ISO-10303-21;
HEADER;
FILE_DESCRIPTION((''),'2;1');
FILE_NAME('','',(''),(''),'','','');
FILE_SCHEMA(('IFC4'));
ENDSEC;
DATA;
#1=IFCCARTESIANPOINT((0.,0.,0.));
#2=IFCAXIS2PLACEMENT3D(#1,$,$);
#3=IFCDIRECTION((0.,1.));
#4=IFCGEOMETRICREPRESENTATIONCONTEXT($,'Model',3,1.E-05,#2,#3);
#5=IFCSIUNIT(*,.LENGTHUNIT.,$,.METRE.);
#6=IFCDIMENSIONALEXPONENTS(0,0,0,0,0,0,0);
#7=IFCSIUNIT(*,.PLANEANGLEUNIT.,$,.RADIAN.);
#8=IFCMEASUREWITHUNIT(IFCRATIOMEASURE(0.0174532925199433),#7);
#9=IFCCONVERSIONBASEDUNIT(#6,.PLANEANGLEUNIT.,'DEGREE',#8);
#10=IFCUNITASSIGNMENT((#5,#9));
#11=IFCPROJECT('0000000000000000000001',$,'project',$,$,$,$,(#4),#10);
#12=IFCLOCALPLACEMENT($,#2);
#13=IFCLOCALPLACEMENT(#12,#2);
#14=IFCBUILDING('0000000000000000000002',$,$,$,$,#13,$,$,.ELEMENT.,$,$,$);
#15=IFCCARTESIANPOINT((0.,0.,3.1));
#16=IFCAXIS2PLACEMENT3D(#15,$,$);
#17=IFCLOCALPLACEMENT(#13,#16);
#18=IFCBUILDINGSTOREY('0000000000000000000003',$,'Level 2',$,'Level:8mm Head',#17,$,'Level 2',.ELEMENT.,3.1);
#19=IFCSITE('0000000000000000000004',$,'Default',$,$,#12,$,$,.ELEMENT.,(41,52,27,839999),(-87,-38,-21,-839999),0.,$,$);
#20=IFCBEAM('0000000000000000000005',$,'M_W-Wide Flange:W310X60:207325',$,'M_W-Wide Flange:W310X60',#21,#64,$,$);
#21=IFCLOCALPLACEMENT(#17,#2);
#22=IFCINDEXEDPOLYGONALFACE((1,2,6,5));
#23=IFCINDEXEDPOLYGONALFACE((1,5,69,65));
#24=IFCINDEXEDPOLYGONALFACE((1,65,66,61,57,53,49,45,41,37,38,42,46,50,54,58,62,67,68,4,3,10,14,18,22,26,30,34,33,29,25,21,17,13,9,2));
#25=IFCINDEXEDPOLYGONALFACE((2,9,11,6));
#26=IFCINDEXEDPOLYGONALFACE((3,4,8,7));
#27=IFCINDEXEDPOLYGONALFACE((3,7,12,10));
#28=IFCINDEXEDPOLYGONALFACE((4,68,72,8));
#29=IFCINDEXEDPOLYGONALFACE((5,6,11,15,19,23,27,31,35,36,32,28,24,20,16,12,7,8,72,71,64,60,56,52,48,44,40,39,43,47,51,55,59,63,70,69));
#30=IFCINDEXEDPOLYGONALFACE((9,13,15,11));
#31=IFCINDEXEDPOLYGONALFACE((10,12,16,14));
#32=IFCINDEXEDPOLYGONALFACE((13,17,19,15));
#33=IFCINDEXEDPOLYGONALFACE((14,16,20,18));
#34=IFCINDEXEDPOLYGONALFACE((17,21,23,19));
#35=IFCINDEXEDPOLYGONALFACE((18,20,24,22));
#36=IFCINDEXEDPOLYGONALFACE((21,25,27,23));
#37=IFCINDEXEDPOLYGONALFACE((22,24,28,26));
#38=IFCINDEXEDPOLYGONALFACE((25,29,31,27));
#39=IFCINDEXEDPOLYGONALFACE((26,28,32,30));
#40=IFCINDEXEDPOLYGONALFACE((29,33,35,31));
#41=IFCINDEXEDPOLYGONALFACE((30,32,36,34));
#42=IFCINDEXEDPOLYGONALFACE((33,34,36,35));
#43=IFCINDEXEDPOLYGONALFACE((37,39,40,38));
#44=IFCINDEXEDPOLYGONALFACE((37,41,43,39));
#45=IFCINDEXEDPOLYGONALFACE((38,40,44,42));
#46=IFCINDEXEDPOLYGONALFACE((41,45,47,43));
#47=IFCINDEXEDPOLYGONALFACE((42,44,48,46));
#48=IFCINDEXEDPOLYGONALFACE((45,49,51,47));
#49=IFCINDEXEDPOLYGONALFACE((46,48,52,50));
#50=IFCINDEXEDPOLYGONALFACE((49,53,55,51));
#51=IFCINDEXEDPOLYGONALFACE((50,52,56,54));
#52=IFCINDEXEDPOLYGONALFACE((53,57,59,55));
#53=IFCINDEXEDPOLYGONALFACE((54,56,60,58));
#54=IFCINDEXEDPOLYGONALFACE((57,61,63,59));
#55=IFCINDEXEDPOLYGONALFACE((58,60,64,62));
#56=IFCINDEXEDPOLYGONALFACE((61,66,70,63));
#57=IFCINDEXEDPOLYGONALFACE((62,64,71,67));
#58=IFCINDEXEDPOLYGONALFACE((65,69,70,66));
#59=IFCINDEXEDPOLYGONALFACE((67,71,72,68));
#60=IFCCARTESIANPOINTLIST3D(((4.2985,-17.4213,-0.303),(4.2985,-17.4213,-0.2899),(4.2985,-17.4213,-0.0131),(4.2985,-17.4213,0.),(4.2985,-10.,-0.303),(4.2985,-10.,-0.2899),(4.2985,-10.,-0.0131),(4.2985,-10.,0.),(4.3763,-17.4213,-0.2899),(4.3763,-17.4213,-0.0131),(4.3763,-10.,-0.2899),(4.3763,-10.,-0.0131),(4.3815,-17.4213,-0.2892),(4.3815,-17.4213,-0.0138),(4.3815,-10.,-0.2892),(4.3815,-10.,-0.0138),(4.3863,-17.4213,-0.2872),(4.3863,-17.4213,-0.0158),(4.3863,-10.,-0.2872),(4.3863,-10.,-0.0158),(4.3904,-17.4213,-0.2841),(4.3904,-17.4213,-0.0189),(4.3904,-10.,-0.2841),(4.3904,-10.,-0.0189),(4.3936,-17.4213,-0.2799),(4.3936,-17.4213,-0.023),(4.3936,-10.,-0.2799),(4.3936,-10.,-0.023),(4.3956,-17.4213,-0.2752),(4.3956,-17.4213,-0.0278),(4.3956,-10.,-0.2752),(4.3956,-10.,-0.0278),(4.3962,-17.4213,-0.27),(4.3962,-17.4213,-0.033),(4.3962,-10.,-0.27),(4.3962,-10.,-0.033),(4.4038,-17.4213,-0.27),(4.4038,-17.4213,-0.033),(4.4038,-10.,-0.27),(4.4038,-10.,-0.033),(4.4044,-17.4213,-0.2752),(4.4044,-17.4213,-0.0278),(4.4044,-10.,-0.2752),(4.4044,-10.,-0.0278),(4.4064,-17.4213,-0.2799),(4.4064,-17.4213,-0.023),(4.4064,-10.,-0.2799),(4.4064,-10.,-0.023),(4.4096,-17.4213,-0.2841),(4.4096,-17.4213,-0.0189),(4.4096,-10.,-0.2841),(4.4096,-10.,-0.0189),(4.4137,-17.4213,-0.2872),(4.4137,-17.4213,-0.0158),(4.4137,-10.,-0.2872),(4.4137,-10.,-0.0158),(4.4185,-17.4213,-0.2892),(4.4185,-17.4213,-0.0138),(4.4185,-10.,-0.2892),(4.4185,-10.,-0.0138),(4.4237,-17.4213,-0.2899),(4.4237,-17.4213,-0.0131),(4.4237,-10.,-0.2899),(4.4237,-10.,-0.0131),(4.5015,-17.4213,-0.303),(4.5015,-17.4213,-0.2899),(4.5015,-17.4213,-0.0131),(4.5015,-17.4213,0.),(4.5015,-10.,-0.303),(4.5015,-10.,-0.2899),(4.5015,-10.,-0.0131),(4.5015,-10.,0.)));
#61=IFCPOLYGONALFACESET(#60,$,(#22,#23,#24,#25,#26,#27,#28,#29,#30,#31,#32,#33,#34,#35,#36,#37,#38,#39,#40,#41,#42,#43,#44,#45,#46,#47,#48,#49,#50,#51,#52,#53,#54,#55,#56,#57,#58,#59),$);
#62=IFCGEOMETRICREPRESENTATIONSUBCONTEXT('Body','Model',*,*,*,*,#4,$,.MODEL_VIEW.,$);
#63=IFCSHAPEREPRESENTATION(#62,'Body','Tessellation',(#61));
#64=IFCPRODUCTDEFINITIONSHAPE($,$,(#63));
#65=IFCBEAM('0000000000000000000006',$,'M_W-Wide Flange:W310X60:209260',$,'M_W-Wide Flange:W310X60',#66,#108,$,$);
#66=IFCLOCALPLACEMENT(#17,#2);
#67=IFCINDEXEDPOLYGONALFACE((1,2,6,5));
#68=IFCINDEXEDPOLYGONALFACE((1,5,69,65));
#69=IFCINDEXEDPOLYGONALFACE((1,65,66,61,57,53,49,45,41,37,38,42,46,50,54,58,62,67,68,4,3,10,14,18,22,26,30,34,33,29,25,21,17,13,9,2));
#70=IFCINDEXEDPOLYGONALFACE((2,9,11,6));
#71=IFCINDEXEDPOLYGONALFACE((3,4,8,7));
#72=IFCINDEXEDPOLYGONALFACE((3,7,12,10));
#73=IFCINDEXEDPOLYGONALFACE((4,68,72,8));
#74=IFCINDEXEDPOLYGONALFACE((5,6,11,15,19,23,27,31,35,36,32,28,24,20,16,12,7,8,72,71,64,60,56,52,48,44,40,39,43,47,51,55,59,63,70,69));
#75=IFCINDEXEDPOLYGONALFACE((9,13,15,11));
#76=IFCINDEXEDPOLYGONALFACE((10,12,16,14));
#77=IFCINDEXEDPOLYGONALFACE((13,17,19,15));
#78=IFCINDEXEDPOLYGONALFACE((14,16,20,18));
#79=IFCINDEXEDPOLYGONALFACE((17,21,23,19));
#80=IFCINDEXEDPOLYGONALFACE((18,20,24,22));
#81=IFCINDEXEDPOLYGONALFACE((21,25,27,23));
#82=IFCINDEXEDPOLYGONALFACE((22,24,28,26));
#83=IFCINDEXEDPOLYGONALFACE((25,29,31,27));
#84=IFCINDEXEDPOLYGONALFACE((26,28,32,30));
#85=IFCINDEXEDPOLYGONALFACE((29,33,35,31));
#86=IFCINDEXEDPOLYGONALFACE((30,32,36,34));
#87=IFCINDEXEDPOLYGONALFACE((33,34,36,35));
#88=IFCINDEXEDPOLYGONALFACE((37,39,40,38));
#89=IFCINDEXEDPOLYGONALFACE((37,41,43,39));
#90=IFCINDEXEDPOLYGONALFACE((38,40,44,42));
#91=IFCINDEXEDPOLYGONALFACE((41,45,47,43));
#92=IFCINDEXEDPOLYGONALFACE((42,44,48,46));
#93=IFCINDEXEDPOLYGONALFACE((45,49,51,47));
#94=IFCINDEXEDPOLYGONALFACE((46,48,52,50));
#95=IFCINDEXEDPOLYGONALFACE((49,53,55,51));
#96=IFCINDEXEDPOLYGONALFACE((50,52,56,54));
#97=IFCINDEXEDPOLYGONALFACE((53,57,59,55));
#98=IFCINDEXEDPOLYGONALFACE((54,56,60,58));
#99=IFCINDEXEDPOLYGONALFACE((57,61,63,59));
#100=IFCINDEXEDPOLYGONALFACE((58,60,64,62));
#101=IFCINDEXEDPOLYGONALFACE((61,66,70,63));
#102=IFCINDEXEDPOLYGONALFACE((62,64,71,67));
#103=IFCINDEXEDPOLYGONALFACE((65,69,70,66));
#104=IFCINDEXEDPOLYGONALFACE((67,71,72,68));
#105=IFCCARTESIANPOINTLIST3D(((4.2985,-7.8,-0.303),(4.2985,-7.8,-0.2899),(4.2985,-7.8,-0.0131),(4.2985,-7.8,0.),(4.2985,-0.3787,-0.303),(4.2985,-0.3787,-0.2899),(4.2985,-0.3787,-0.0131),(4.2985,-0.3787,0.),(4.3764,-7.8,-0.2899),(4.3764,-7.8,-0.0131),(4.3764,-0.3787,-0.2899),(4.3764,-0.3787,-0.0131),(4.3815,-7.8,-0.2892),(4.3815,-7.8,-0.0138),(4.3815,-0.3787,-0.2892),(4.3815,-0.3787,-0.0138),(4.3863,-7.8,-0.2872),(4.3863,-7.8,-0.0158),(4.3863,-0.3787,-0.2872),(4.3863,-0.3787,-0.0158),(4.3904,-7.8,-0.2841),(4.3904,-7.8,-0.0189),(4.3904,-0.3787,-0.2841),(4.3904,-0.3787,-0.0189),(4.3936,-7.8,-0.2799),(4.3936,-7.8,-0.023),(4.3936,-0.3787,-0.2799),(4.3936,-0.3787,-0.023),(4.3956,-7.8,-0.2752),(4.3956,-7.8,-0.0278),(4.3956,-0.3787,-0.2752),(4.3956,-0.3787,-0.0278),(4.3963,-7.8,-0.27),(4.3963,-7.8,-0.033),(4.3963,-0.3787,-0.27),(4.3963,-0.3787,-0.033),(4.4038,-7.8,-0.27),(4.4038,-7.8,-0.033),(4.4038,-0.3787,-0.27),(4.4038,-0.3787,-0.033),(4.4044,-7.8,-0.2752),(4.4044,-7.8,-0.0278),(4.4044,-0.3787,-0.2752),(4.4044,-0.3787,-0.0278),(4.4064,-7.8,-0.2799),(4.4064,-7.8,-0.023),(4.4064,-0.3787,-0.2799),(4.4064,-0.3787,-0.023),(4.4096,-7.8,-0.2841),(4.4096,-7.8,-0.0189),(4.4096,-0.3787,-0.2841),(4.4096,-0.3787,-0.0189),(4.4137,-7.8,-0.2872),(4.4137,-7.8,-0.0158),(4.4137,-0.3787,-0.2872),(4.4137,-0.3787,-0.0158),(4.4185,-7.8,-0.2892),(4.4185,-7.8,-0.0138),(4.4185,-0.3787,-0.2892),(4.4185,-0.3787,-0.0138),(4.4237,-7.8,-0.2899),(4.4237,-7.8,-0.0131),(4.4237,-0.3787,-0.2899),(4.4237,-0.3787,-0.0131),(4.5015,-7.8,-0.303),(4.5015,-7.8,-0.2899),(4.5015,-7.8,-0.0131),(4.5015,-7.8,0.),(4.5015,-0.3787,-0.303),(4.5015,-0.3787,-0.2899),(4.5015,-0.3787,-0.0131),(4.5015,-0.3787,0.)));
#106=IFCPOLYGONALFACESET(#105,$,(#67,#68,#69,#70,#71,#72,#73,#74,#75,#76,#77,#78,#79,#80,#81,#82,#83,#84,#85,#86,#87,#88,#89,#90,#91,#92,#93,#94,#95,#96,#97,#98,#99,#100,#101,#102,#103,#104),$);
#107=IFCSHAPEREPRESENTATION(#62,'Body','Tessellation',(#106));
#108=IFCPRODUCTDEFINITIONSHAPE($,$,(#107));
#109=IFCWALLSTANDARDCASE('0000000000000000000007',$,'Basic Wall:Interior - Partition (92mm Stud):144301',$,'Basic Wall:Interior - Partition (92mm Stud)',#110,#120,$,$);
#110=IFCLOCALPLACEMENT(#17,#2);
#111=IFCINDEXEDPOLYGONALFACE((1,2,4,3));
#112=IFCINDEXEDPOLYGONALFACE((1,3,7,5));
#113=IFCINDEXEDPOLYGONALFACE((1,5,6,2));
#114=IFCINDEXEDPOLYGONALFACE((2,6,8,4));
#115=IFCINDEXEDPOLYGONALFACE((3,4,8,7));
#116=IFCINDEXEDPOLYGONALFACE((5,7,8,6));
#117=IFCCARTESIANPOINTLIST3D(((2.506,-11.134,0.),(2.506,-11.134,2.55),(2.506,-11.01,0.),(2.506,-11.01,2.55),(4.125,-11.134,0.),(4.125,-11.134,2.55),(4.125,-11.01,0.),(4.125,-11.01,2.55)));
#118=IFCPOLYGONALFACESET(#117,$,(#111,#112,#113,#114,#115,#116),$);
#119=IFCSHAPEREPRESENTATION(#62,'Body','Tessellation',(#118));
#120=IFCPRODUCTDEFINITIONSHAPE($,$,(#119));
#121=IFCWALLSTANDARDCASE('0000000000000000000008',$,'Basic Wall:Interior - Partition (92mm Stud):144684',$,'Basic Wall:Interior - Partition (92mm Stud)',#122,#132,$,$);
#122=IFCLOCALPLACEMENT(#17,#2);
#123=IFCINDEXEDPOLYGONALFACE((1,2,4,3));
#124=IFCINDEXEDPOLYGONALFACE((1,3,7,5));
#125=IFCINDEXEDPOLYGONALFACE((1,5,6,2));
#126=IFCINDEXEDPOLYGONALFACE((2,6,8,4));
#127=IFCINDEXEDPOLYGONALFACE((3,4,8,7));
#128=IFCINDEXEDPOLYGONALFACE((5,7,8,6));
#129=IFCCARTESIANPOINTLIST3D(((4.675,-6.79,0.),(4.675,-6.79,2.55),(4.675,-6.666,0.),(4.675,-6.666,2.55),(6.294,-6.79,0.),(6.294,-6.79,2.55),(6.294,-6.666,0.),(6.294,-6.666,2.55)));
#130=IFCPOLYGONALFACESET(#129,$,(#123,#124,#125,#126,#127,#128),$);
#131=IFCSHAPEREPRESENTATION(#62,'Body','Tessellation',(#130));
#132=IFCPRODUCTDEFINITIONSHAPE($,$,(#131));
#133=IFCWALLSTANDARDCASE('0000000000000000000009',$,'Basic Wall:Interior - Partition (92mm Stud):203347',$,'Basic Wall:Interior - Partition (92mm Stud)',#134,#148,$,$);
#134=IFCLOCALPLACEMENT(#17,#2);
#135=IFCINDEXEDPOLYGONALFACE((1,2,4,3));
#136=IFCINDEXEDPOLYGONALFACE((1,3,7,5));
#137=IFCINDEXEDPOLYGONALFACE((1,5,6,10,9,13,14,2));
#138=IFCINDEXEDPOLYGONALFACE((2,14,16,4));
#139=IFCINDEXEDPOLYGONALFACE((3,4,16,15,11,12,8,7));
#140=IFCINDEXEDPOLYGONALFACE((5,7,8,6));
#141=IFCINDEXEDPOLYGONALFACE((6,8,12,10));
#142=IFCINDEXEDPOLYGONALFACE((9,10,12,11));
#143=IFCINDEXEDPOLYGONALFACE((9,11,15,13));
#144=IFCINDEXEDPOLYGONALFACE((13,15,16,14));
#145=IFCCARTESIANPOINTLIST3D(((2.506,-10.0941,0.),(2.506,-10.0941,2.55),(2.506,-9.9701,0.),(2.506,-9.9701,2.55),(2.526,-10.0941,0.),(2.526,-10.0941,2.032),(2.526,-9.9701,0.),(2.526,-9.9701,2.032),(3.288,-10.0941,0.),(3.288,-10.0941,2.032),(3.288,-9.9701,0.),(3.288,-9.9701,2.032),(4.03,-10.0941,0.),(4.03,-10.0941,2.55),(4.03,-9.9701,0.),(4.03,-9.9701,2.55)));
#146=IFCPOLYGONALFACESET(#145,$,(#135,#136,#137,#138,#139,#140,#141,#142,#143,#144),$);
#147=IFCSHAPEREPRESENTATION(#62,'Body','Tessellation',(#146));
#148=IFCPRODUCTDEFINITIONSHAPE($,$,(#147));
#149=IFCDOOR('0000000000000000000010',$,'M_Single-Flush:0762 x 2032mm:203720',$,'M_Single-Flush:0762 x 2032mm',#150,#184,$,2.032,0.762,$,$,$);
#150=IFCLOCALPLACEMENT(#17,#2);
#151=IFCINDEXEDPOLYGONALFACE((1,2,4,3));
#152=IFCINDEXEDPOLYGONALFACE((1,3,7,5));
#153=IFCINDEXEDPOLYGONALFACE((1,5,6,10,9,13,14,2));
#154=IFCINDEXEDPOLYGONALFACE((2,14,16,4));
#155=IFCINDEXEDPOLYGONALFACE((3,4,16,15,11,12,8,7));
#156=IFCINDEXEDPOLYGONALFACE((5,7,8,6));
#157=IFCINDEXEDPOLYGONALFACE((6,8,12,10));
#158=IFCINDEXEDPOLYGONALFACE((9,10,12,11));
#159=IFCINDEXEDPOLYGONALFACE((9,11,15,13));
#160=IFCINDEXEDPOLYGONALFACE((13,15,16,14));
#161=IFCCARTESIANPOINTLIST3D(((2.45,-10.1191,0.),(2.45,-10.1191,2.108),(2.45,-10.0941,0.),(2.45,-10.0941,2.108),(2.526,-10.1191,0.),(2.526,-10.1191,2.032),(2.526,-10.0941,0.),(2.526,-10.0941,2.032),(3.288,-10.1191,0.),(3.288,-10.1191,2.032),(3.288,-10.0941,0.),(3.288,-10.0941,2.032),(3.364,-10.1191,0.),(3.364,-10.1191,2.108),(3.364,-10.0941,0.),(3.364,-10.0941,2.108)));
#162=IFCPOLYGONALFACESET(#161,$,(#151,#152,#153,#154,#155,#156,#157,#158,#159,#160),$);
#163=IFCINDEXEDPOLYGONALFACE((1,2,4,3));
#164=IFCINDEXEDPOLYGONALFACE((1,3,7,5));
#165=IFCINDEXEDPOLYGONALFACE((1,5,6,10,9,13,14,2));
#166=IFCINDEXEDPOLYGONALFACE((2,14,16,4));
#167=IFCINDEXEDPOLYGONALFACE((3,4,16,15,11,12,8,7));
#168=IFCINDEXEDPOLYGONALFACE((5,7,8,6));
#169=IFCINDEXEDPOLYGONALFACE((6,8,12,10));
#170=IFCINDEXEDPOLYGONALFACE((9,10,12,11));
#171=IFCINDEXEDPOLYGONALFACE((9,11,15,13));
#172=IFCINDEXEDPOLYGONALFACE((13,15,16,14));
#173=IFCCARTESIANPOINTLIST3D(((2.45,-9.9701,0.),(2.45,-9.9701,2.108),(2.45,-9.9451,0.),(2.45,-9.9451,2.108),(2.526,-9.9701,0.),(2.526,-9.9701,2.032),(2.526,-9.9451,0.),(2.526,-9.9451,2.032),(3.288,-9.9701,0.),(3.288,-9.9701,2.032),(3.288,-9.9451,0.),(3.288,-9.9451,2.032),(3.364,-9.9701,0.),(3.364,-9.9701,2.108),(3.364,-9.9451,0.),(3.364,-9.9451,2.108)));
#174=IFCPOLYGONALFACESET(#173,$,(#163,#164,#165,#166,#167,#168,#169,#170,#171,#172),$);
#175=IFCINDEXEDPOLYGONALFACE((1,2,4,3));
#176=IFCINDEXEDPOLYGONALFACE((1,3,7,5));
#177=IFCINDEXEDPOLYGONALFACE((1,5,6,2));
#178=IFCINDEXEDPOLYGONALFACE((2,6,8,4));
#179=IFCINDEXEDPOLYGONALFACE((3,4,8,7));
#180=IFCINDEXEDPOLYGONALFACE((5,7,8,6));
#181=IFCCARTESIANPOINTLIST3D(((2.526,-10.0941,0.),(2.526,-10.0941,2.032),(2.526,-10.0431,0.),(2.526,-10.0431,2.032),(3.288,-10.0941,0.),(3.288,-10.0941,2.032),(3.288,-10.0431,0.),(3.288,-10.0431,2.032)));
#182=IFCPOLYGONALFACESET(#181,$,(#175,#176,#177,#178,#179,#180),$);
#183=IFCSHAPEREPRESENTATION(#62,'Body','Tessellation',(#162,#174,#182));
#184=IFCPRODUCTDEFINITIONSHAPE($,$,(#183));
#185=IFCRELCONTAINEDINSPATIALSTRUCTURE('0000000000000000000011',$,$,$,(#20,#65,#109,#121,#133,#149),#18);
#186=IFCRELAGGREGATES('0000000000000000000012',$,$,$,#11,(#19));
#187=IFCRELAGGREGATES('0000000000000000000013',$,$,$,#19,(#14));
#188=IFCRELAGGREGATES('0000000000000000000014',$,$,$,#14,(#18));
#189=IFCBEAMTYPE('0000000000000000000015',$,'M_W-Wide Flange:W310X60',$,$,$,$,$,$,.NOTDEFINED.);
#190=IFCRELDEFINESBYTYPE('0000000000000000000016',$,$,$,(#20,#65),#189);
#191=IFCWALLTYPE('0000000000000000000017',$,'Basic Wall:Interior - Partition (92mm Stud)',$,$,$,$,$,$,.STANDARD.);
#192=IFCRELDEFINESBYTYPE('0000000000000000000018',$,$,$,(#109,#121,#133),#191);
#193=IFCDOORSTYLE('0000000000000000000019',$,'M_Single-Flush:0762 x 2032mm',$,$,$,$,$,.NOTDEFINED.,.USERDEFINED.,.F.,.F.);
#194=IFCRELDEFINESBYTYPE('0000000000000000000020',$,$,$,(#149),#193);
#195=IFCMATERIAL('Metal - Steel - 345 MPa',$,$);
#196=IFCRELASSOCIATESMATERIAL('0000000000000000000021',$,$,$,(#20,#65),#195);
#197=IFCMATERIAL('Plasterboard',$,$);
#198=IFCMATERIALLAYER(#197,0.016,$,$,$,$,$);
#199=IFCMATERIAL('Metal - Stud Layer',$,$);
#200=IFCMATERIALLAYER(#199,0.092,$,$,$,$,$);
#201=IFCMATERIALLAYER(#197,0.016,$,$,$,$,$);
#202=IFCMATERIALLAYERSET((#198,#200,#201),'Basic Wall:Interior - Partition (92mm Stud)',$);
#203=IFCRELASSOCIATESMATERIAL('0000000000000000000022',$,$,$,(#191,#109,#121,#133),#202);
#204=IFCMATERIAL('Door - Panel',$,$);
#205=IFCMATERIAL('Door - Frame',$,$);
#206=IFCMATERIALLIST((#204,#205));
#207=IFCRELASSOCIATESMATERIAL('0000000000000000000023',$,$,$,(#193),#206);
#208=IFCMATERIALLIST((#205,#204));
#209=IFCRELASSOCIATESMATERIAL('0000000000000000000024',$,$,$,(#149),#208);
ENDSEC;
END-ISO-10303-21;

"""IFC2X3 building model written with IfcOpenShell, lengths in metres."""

from ifc_helpers import new_model, entity, si_unit, converted_unit, direction, frame, frame_2d, origin, origin_2d_with_axis, place, context, subcontext, project, spatial, polyline, rectangle, i_section, outline, extrude, source, transform, mapped, material, material_list, layer, layer_set, layer_usage, type_object, type_shapes, element, fill, save


model = new_model("IFC2X3")

# Units and contexts
model_context = context("Model", 3, precision=1e-05, world=origin(), true_north=direction((0.0, 1.0)))
body_context = subcontext(model_context, "Body", "Model", "MODEL_VIEW")
ifc_project = project(units=[si_unit("LENGTHUNIT", "METRE"), converted_unit("PLANEANGLEUNIT", "DEGREE", entity("IfcRatioMeasure", 0.0174532925199433), si_unit("PLANEANGLEUNIT", "RADIAN"), dimensions=[0, 0, 0, 0, 0, 0, 0])], contexts=[model_context])

# Site, building, storey
site_placement = place(None, origin())
site = spatial("IfcSite", under=ifc_project, at=site_placement, Name="Default", CompositionType="ELEMENT", RefLatitude=(41, 52, 27, 839999), RefLongitude=(-87, -38, -21, -839999), RefElevation=0.0)
building_placement = place(site_placement, origin())
building = spatial("IfcBuilding", under=site, at=building_placement, CompositionType="ELEMENT")
storey_placement = place(building_placement, frame((0.0, 0.0, 3.1)))
storey = spatial("IfcBuildingStorey", under=building, at=storey_placement, Name="Level 2", ObjectType="Level:8mm Head", LongName="Level 2", CompositionType="ELEMENT", Elevation=3.1)

# Beams
ifc_material_1 = material(Name="Metal - Steel - 345 MPa")
beam_type = type_object("IfcBeamType", Name="M_W-Wide Flange:W310X60", PredefinedType="NOTDEFINED")
beam_1_placement = place(storey_placement, frame((4.4, -10.0, 0.0), z_axis=(0.0, 0.0, 1.0), x_axis=(0.0, -1.0, 0.0)))
element("IfcBeam", 1, at=beam_1_placement, inside=storey, type_object=beam_type, material=ifc_material_1, Name="M_W-Wide Flange:W310X60:207325", ObjectType="M_W-Wide Flange:W310X60", context=body_context, shape_type="SweptSolid", body=[
    extrude(i_section(OverallWidth=0.203, OverallDepth=0.303, WebThickness=0.0075, FlangeThickness=0.0131, FilletRadius=0.0199, at=frame_2d((0.0, 0.0), x_axis=(0.0, 1.0))), frame((0.0, 0.0, -0.1515), z_axis=(1.0, 0.0, 0.0), x_axis=(0.0, 0.0, -1.0)), (0.0, 0.0, 1.0), 7.4213),
])
beam_2_placement = place(storey_placement, frame((4.4, -7.8, 0.0), z_axis=(0.0, 0.0, 1.0), x_axis=(0.0, 1.0, 0.0)))
element("IfcBeam", 2, at=beam_2_placement, inside=storey, type_object=beam_type, material=ifc_material_1, Name="M_W-Wide Flange:W310X60:209260", ObjectType="M_W-Wide Flange:W310X60", context=body_context, shape_type="SweptSolid", body=[
    extrude(i_section(OverallWidth=0.203, OverallDepth=0.303, WebThickness=0.0075, FlangeThickness=0.0131, FilletRadius=0.0199, at=frame_2d((0.0, 0.0), x_axis=(0.0, 1.0))), frame((0.0, 0.0, -0.1515), z_axis=(1.0, 0.0, 0.0), x_axis=(0.0, 0.0, -1.0)), (0.0, 0.0, 1.0), 7.4213),
])

# Walls
ifc_material_2 = material(Name="Plasterboard")
ifc_layer_1 = layer(ifc_material_2, 0.016)
ifc_material_3 = material(Name="Metal - Stud Layer")
ifc_layer_2 = layer(ifc_material_3, 0.092)
ifc_layer_3 = layer(ifc_material_2, 0.016)
ifc_layer_set_1 = layer_set([ifc_layer_1, ifc_layer_2, ifc_layer_3], Name="Basic Wall:Interior - Partition (92mm Stud)")
ifc_layer_usage_1 = layer_usage(ifc_layer_set_1, "AXIS2", "NEGATIVE", 0.062)
wall_type_1 = type_object("IfcWallType", Name="Basic Wall:Interior - Partition (92mm Stud)", PredefinedType="STANDARD", material=ifc_layer_set_1)
wall_1_placement = place(storey_placement, frame((4.125, -11.072, 0.0), z_axis=(0.0, 0.0, 1.0), x_axis=(-1.0, 0.0, 0.0)))
element("IfcWallStandardCase", 3, at=wall_1_placement, inside=storey, type_object=wall_type_1, material=ifc_layer_usage_1, Name="Basic Wall:Interior - Partition (92mm Stud):144301", ObjectType="Basic Wall:Interior - Partition (92mm Stud)", context=body_context, shape_type="SweptSolid", body=[
    extrude(rectangle(XDim=1.619, YDim=0.124, at=frame_2d((0.8095, 0.0), x_axis=(-1.0, 0.0))), origin(), (0.0, 0.0, 1.0), 2.55),
])
ifc_layer_usage_2 = layer_usage(ifc_layer_set_1, "AXIS2", "NEGATIVE", 0.062)
wall_2_placement = place(storey_placement, frame((4.675, -6.728, 0.0)))
element("IfcWallStandardCase", 4, at=wall_2_placement, inside=storey, type_object=wall_type_1, material=ifc_layer_usage_2, Name="Basic Wall:Interior - Partition (92mm Stud):144684", ObjectType="Basic Wall:Interior - Partition (92mm Stud)", context=body_context, shape_type="SweptSolid", body=[
    extrude(rectangle(XDim=1.619, YDim=0.124, at=frame_2d((0.8095, 0.0), x_axis=(-1.0, 0.0))), origin(), (0.0, 0.0, 1.0), 2.55),
])

# Wall, opening, door
ifc_layer_usage_3 = layer_usage(ifc_layer_set_1, "AXIS2", "NEGATIVE", 0.062)
wall_3_placement = place(storey_placement, frame((4.03, -10.0321, 0.0), z_axis=(0.0, 0.0, 1.0), x_axis=(-1.0, 0.0, 0.0)))
wall_3 = element("IfcWallStandardCase", 5, at=wall_3_placement, inside=storey, type_object=wall_type_1, material=ifc_layer_usage_3, Name="Basic Wall:Interior - Partition (92mm Stud):203347", ObjectType="Basic Wall:Interior - Partition (92mm Stud)", context=body_context, shape_type="SweptSolid", body=[
    extrude(rectangle(XDim=1.524, YDim=0.124, at=frame_2d((0.762, 0.0), x_axis=(-1.0, 0.0))), origin(), (0.0, 0.0, 1.0), 2.55),
])
opening_1_placement = place(wall_3_placement, frame((0.742, -0.062, 0.0)))
opening_1 = element("IfcOpeningElement", 6, at=opening_1_placement, cuts=wall_3, ObjectType="Opening", context=body_context, shape_type="SweptSolid", body=[
    extrude(rectangle(XDim=0.762, YDim=2.032, at=frame_2d((1.016, 0.381), x_axis=(0.0, 1.0))), frame((0.0, 0.0, 0.0), z_axis=(0.0, 1.0, 0.0), x_axis=(0.0, 0.0, 1.0)), (0.0, 0.0, 1.0), 0.124),
])
ifc_material_4 = material(Name="Door - Frame")
ifc_material_5 = material(Name="Door - Panel")
ifc_material_list_1 = material_list([ifc_material_4, ifc_material_5])
ifc_material_list_2 = material_list([ifc_material_5, ifc_material_4])
door_style = type_object("IfcDoorStyle", Name="M_Single-Flush:0762 x 2032mm", ConstructionType="USERDEFINED", OperationType="NOTDEFINED", ParameterTakesPrecedence=False, Sizeable=False, material=ifc_material_list_2)
shared_shape_1 = source(origin(), body_context, "Body", "SweptSolid", [
    extrude(outline(polyline([(-0.457, -1.073), (0.457, -1.073), (0.457, 1.035), (0.381, 1.035), (0.381, -0.997), (-0.381, -0.997), (-0.381, 1.035), (-0.457, 1.035), (-0.457, -1.073)])), frame((0.381, 0.124, 1.035), z_axis=(0.0, 1.0, 0.0), x_axis=(1.0, 0.0, 0.0)), (0.0, 0.0, 1.0), 0.025),
    extrude(outline(polyline([(-1.073, -0.457), (1.035, -0.457), (1.035, -0.381), (-0.997, -0.381), (-0.997, 0.381), (1.035, 0.381), (1.035, 0.457), (-1.073, 0.457), (-1.073, -0.457)])), frame((0.381, -0.025, 1.035), z_axis=(0.0, 1.0, 0.0), x_axis=(0.0, 0.0, -1.0)), (0.0, 0.0, 1.0), 0.025),
    extrude(rectangle(XDim=0.051, YDim=0.762, at=origin_2d_with_axis()), frame((0.381, 0.0985, 0.0), z_axis=(0.0, 0.0, 1.0), x_axis=(0.0, 1.0, 0.0)), (0.0, 0.0, 1.0), 2.032),
])
type_shapes(door_style, [shared_shape_1])
door_1_placement = place(opening_1_placement, origin())
door_1 = element("IfcDoor", 7, at=door_1_placement, inside=storey, type_object=door_style, material=ifc_material_list_1, Name="M_Single-Flush:0762 x 2032mm:203720", ObjectType="M_Single-Flush:0762 x 2032mm", OverallHeight=2.032, OverallWidth=0.762, context=body_context, shape_type="MappedRepresentation", body=[
    mapped(shared_shape_1, transform((0.0, 0.0, 0.0), scale=1.0)),
])
fill(opening_1, door_1)

save(model, "model.ifc")
